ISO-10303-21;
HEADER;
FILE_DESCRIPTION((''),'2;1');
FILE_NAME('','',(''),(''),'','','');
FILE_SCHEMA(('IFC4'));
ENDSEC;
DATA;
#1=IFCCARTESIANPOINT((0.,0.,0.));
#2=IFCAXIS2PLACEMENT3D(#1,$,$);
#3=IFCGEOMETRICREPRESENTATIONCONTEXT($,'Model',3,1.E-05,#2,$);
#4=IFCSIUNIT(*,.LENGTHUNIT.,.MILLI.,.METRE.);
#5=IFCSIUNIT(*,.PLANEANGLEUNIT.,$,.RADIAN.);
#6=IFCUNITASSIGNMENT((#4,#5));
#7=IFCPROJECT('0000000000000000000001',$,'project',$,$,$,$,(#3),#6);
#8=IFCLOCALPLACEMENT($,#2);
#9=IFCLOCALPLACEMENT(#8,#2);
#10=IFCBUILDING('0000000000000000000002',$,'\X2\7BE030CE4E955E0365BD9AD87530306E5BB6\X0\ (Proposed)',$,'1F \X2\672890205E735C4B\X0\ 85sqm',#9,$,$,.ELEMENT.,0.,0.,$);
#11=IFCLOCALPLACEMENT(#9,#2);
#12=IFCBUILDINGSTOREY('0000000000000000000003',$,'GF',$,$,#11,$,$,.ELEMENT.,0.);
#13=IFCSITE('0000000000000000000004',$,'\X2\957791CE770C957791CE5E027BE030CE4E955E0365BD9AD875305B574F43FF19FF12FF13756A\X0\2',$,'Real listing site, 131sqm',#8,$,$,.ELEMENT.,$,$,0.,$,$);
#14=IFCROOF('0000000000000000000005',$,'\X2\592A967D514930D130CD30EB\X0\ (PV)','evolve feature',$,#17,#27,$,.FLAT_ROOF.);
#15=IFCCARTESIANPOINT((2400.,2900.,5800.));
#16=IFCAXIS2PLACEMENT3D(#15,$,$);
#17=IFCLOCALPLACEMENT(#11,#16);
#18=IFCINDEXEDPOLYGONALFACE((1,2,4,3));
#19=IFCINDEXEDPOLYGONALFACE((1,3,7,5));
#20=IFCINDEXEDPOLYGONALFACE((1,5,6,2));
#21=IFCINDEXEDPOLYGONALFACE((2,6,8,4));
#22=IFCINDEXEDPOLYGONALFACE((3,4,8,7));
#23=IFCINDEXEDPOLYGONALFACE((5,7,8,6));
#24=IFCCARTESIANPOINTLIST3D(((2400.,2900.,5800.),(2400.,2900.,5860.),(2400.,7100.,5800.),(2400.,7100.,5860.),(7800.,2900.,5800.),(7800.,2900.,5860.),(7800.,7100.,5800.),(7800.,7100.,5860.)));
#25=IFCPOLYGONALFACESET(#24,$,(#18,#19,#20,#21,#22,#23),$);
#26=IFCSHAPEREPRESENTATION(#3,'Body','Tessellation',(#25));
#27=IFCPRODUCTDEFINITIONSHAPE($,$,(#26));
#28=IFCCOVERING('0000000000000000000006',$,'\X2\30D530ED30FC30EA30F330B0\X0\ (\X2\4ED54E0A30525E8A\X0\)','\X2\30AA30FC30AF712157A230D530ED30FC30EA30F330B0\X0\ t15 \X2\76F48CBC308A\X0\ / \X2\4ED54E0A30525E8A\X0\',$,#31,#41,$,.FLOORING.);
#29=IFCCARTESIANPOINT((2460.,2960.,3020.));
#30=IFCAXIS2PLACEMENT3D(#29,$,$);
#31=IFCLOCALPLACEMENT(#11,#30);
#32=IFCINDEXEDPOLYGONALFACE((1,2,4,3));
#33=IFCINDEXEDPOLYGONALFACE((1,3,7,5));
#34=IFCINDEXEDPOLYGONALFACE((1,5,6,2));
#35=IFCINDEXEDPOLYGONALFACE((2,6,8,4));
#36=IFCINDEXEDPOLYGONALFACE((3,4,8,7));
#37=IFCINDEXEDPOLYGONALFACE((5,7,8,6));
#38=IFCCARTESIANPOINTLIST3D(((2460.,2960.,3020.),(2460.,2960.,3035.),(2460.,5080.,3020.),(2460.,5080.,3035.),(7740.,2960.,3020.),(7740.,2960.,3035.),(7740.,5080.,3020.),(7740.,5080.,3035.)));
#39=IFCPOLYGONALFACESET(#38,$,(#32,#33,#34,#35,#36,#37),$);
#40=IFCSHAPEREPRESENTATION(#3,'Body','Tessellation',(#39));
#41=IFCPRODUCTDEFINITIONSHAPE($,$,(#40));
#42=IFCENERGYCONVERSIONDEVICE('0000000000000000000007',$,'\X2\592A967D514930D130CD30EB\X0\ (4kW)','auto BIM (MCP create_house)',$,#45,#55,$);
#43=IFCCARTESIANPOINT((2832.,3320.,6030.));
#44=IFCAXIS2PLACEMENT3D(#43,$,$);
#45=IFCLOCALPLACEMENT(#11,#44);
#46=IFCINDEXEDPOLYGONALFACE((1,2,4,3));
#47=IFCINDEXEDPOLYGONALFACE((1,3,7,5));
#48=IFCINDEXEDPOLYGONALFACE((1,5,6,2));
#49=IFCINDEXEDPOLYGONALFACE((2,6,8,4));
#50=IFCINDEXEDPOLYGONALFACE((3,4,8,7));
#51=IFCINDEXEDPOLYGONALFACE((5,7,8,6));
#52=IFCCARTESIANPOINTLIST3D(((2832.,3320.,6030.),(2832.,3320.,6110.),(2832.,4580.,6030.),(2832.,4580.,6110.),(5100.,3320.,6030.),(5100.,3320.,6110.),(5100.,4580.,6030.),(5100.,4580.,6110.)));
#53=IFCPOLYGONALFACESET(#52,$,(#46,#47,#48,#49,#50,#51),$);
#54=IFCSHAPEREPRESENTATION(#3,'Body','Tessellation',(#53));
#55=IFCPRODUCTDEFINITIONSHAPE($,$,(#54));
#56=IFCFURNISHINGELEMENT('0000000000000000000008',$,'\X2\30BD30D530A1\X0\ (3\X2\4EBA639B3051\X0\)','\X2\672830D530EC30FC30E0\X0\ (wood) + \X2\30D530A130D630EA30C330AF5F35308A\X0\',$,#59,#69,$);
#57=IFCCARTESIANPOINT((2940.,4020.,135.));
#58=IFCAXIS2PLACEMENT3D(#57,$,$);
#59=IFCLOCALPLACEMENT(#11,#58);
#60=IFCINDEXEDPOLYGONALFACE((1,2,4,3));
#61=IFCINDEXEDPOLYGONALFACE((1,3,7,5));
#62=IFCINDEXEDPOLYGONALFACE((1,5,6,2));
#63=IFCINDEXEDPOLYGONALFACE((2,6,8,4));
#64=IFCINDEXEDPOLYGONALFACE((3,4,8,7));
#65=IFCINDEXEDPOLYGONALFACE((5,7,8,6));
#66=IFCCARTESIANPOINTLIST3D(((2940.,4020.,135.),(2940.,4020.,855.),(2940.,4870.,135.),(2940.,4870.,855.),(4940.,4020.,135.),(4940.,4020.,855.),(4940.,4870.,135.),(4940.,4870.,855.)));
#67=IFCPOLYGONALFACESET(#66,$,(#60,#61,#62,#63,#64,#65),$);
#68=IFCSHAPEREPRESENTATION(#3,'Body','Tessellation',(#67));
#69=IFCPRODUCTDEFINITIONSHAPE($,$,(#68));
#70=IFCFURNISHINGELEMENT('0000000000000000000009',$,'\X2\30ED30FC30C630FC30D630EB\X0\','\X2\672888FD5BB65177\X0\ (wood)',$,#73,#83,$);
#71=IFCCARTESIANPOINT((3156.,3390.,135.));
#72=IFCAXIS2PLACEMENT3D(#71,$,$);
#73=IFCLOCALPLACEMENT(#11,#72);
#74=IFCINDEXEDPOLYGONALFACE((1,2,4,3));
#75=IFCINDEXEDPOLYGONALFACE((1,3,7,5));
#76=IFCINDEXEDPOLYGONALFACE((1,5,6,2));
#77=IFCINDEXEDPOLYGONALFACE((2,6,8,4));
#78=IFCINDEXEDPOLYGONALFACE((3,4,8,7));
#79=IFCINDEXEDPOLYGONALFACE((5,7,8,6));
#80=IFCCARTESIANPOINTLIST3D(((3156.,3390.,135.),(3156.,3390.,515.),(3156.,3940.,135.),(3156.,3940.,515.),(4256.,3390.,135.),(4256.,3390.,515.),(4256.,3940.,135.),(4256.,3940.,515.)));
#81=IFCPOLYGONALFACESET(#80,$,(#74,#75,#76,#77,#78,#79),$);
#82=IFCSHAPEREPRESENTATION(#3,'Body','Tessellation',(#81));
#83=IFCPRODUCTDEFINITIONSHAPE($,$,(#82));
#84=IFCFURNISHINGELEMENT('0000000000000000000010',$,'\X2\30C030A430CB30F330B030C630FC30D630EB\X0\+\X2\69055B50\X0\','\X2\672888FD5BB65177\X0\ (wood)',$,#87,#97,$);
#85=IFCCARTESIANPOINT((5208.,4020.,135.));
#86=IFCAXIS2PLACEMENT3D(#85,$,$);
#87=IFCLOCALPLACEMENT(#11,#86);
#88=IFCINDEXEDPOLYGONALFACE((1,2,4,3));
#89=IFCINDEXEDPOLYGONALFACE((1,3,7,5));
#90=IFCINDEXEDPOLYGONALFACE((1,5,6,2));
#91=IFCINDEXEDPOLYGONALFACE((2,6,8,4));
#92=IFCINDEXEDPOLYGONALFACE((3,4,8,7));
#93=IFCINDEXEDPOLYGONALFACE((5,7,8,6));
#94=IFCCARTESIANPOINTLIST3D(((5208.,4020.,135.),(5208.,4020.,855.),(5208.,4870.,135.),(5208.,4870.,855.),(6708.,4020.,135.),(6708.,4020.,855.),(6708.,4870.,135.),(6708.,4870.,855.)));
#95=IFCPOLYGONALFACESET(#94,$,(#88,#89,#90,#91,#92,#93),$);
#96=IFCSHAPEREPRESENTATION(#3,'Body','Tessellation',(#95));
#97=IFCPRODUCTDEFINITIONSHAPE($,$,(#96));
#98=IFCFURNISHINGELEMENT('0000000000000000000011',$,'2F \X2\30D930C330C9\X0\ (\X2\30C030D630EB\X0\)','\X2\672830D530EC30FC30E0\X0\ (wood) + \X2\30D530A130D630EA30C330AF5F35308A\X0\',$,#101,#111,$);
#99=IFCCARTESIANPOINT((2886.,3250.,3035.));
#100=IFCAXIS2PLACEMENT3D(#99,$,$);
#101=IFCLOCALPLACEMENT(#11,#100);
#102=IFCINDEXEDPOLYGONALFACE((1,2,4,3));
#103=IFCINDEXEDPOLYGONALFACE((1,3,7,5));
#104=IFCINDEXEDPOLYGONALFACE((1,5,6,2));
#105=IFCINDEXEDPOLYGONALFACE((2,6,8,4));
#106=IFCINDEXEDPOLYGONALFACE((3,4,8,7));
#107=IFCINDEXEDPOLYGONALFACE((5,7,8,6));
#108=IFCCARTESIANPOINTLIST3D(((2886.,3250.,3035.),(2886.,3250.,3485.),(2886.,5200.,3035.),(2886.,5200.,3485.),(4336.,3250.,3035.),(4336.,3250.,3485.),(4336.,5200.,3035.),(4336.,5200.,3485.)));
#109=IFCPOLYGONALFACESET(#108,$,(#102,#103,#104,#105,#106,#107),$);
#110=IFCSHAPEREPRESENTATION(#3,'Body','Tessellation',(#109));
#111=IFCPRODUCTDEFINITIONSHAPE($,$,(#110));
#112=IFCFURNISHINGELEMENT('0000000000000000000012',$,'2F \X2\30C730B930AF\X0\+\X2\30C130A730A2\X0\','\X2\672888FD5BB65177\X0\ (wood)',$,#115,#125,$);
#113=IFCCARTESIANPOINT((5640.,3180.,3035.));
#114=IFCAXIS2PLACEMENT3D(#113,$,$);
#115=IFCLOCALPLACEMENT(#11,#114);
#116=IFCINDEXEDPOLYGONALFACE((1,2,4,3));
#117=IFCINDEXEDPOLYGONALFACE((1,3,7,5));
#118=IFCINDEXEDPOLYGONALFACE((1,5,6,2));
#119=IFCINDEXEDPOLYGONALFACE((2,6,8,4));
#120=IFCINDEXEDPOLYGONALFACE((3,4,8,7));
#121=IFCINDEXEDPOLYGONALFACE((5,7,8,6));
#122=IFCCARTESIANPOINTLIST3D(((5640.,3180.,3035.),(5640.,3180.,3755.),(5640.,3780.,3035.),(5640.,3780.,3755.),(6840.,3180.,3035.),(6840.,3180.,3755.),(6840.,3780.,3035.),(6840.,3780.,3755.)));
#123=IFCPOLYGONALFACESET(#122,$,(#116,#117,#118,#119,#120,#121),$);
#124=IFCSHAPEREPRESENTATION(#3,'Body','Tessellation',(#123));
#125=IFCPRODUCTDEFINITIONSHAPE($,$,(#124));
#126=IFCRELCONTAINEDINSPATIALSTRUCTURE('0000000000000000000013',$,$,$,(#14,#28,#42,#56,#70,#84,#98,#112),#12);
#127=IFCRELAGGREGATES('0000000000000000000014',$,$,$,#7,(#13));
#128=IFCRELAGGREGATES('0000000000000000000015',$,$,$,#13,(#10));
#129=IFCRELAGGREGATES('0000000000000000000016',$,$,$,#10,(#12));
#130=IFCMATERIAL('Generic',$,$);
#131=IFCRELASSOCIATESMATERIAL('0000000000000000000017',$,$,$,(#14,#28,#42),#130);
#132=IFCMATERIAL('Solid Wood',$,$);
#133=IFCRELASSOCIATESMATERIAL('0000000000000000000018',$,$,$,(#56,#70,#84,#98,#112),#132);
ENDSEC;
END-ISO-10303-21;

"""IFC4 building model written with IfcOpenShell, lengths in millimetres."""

from ifc_helpers import new_model, si_unit, frame, frame_2d, origin, place, context, project, spatial, rectangle, extrude, material, element, save


model = new_model("IFC4")

# Units and contexts
model_context = context("Model", 3, precision=1e-05, world=origin())
ifc_project = project(units=[si_unit("LENGTHUNIT", "METRE", prefix="MILLI"), si_unit("PLANEANGLEUNIT", "RADIAN")], contexts=[model_context])

# Site, building, storey
site_placement = place(None, origin())
site = spatial("IfcSite", under=ifc_project, at=site_placement, Name="長野県長野市篠ノ井布施高田字佃９２３番2", ObjectType="Real listing site, 131sqm", CompositionType="ELEMENT", RefElevation=0.0)
building_placement = place(site_placement, origin())
building = spatial("IfcBuilding", under=site, at=building_placement, Name="篠ノ井布施高田の家 (Proposed)", ObjectType="1F 木造平屋 85sqm", CompositionType="ELEMENT", ElevationOfRefHeight=0.0, ElevationOfTerrain=0.0)
storey_placement = place(building_placement, origin())
storey = spatial("IfcBuildingStorey", under=building, at=storey_placement, Name="GF", CompositionType="ELEMENT", Elevation=0.0)

# Shared definitions
ifc_material_1 = material(Name="Solid Wood")

# Roof
ifc_material_2 = material(Name="Generic")
roof_1_placement = place(storey_placement, frame((2400.0, 2900.0, 5800.0)))
element("IfcRoof", 1, at=roof_1_placement, inside=storey, material=ifc_material_2, Name="太陽光パネル (PV)", Description="evolve feature", PredefinedType="FLAT_ROOF", context=model_context, shape_type="SweptSolid", body=[
    extrude(rectangle(XDim=5400.0, YDim=4200.0, at=frame_2d((2700.0, 2100.0))), frame((2400.0, 2900.0, 5800.0)), (0.0, 0.0, 1.0), 60.0),
])

# Covering
covering_placement = place(storey_placement, frame((2460.0, 2960.0, 3020.0)))
element("IfcCovering", 2, at=covering_placement, inside=storey, material=ifc_material_2, Name="フローリング (仕上げ床)", Description="オーク無垢フローリング t15 直貼り / 仕上げ床", PredefinedType="FLOORING", context=model_context, shape_type="SweptSolid", body=[
    extrude(rectangle(XDim=5280.0, YDim=2120.0, at=frame_2d((2640.0, 1060.0))), frame((2460.0, 2960.0, 3020.0)), (0.0, 0.0, 1.0), 15.0),
])

# Energy conversion device
energy_conversion_device_placement = place(storey_placement, frame((2832.0, 3320.0, 6030.0)))
element("IfcEnergyConversionDevice", 3, at=energy_conversion_device_placement, inside=storey, material=ifc_material_2, Name="太陽光パネル (4kW)", Description="auto BIM (MCP create_house)", context=model_context, shape_type="SweptSolid", body=[
    extrude(rectangle(XDim=2268.0, YDim=1260.0, at=frame_2d((1134.0, 630.0))), frame((2832.0, 3320.0, 6030.0)), (0.0, 0.0, 1.0), 80.0),
])

# Furnishing elements
furnishing_1_placement = place(storey_placement, frame((2940.0, 4020.0, 135.0)))
element("IfcFurnishingElement", 4, at=furnishing_1_placement, inside=storey, material=ifc_material_1, Name="ソファ (3人掛け)", Description="木フレーム (wood) + ファブリック張り", context=model_context, shape_type="SweptSolid", body=[
    extrude(rectangle(XDim=2000.0, YDim=850.0, at=frame_2d((1000.0, 425.0))), frame((2940.0, 4020.0, 135.0)), (0.0, 0.0, 1.0), 720.0),
])
furnishing_2_placement = place(storey_placement, frame((3156.0, 3390.0, 135.0)))
element("IfcFurnishingElement", 5, at=furnishing_2_placement, inside=storey, material=ifc_material_1, Name="ローテーブル", Description="木製家具 (wood)", context=model_context, shape_type="SweptSolid", body=[
    extrude(rectangle(XDim=1100.0, YDim=550.0, at=frame_2d((550.0, 275.0))), frame((3156.0, 3390.0, 135.0)), (0.0, 0.0, 1.0), 380.0),
])
furnishing_3_placement = place(storey_placement, frame((5208.0, 4020.0, 135.0)))
element("IfcFurnishingElement", 6, at=furnishing_3_placement, inside=storey, material=ifc_material_1, Name="ダイニングテーブル+椅子", Description="木製家具 (wood)", context=model_context, shape_type="SweptSolid", body=[
    extrude(rectangle(XDim=1500.0, YDim=850.0, at=frame_2d((750.0, 425.0))), frame((5208.0, 4020.0, 135.0)), (0.0, 0.0, 1.0), 720.0),
])
furnishing_4_placement = place(storey_placement, frame((2886.0, 3250.0, 3035.0)))
element("IfcFurnishingElement", 7, at=furnishing_4_placement, inside=storey, material=ifc_material_1, Name="2F ベッド (ダブル)", Description="木フレーム (wood) + ファブリック張り", context=model_context, shape_type="SweptSolid", body=[
    extrude(rectangle(XDim=1450.0, YDim=1950.0, at=frame_2d((725.0, 975.0))), frame((2886.0, 3250.0, 3035.0)), (0.0, 0.0, 1.0), 450.0),
])
furnishing_5_placement = place(storey_placement, frame((5640.0, 3180.0, 3035.0)))
element("IfcFurnishingElement", 8, at=furnishing_5_placement, inside=storey, material=ifc_material_1, Name="2F デスク+チェア", Description="木製家具 (wood)", context=model_context, shape_type="SweptSolid", body=[
    extrude(rectangle(XDim=1200.0, YDim=600.0, at=frame_2d((600.0, 300.0))), frame((5640.0, 3180.0, 3035.0)), (0.0, 0.0, 1.0), 720.0),
])

save(model, "model.ifc")
